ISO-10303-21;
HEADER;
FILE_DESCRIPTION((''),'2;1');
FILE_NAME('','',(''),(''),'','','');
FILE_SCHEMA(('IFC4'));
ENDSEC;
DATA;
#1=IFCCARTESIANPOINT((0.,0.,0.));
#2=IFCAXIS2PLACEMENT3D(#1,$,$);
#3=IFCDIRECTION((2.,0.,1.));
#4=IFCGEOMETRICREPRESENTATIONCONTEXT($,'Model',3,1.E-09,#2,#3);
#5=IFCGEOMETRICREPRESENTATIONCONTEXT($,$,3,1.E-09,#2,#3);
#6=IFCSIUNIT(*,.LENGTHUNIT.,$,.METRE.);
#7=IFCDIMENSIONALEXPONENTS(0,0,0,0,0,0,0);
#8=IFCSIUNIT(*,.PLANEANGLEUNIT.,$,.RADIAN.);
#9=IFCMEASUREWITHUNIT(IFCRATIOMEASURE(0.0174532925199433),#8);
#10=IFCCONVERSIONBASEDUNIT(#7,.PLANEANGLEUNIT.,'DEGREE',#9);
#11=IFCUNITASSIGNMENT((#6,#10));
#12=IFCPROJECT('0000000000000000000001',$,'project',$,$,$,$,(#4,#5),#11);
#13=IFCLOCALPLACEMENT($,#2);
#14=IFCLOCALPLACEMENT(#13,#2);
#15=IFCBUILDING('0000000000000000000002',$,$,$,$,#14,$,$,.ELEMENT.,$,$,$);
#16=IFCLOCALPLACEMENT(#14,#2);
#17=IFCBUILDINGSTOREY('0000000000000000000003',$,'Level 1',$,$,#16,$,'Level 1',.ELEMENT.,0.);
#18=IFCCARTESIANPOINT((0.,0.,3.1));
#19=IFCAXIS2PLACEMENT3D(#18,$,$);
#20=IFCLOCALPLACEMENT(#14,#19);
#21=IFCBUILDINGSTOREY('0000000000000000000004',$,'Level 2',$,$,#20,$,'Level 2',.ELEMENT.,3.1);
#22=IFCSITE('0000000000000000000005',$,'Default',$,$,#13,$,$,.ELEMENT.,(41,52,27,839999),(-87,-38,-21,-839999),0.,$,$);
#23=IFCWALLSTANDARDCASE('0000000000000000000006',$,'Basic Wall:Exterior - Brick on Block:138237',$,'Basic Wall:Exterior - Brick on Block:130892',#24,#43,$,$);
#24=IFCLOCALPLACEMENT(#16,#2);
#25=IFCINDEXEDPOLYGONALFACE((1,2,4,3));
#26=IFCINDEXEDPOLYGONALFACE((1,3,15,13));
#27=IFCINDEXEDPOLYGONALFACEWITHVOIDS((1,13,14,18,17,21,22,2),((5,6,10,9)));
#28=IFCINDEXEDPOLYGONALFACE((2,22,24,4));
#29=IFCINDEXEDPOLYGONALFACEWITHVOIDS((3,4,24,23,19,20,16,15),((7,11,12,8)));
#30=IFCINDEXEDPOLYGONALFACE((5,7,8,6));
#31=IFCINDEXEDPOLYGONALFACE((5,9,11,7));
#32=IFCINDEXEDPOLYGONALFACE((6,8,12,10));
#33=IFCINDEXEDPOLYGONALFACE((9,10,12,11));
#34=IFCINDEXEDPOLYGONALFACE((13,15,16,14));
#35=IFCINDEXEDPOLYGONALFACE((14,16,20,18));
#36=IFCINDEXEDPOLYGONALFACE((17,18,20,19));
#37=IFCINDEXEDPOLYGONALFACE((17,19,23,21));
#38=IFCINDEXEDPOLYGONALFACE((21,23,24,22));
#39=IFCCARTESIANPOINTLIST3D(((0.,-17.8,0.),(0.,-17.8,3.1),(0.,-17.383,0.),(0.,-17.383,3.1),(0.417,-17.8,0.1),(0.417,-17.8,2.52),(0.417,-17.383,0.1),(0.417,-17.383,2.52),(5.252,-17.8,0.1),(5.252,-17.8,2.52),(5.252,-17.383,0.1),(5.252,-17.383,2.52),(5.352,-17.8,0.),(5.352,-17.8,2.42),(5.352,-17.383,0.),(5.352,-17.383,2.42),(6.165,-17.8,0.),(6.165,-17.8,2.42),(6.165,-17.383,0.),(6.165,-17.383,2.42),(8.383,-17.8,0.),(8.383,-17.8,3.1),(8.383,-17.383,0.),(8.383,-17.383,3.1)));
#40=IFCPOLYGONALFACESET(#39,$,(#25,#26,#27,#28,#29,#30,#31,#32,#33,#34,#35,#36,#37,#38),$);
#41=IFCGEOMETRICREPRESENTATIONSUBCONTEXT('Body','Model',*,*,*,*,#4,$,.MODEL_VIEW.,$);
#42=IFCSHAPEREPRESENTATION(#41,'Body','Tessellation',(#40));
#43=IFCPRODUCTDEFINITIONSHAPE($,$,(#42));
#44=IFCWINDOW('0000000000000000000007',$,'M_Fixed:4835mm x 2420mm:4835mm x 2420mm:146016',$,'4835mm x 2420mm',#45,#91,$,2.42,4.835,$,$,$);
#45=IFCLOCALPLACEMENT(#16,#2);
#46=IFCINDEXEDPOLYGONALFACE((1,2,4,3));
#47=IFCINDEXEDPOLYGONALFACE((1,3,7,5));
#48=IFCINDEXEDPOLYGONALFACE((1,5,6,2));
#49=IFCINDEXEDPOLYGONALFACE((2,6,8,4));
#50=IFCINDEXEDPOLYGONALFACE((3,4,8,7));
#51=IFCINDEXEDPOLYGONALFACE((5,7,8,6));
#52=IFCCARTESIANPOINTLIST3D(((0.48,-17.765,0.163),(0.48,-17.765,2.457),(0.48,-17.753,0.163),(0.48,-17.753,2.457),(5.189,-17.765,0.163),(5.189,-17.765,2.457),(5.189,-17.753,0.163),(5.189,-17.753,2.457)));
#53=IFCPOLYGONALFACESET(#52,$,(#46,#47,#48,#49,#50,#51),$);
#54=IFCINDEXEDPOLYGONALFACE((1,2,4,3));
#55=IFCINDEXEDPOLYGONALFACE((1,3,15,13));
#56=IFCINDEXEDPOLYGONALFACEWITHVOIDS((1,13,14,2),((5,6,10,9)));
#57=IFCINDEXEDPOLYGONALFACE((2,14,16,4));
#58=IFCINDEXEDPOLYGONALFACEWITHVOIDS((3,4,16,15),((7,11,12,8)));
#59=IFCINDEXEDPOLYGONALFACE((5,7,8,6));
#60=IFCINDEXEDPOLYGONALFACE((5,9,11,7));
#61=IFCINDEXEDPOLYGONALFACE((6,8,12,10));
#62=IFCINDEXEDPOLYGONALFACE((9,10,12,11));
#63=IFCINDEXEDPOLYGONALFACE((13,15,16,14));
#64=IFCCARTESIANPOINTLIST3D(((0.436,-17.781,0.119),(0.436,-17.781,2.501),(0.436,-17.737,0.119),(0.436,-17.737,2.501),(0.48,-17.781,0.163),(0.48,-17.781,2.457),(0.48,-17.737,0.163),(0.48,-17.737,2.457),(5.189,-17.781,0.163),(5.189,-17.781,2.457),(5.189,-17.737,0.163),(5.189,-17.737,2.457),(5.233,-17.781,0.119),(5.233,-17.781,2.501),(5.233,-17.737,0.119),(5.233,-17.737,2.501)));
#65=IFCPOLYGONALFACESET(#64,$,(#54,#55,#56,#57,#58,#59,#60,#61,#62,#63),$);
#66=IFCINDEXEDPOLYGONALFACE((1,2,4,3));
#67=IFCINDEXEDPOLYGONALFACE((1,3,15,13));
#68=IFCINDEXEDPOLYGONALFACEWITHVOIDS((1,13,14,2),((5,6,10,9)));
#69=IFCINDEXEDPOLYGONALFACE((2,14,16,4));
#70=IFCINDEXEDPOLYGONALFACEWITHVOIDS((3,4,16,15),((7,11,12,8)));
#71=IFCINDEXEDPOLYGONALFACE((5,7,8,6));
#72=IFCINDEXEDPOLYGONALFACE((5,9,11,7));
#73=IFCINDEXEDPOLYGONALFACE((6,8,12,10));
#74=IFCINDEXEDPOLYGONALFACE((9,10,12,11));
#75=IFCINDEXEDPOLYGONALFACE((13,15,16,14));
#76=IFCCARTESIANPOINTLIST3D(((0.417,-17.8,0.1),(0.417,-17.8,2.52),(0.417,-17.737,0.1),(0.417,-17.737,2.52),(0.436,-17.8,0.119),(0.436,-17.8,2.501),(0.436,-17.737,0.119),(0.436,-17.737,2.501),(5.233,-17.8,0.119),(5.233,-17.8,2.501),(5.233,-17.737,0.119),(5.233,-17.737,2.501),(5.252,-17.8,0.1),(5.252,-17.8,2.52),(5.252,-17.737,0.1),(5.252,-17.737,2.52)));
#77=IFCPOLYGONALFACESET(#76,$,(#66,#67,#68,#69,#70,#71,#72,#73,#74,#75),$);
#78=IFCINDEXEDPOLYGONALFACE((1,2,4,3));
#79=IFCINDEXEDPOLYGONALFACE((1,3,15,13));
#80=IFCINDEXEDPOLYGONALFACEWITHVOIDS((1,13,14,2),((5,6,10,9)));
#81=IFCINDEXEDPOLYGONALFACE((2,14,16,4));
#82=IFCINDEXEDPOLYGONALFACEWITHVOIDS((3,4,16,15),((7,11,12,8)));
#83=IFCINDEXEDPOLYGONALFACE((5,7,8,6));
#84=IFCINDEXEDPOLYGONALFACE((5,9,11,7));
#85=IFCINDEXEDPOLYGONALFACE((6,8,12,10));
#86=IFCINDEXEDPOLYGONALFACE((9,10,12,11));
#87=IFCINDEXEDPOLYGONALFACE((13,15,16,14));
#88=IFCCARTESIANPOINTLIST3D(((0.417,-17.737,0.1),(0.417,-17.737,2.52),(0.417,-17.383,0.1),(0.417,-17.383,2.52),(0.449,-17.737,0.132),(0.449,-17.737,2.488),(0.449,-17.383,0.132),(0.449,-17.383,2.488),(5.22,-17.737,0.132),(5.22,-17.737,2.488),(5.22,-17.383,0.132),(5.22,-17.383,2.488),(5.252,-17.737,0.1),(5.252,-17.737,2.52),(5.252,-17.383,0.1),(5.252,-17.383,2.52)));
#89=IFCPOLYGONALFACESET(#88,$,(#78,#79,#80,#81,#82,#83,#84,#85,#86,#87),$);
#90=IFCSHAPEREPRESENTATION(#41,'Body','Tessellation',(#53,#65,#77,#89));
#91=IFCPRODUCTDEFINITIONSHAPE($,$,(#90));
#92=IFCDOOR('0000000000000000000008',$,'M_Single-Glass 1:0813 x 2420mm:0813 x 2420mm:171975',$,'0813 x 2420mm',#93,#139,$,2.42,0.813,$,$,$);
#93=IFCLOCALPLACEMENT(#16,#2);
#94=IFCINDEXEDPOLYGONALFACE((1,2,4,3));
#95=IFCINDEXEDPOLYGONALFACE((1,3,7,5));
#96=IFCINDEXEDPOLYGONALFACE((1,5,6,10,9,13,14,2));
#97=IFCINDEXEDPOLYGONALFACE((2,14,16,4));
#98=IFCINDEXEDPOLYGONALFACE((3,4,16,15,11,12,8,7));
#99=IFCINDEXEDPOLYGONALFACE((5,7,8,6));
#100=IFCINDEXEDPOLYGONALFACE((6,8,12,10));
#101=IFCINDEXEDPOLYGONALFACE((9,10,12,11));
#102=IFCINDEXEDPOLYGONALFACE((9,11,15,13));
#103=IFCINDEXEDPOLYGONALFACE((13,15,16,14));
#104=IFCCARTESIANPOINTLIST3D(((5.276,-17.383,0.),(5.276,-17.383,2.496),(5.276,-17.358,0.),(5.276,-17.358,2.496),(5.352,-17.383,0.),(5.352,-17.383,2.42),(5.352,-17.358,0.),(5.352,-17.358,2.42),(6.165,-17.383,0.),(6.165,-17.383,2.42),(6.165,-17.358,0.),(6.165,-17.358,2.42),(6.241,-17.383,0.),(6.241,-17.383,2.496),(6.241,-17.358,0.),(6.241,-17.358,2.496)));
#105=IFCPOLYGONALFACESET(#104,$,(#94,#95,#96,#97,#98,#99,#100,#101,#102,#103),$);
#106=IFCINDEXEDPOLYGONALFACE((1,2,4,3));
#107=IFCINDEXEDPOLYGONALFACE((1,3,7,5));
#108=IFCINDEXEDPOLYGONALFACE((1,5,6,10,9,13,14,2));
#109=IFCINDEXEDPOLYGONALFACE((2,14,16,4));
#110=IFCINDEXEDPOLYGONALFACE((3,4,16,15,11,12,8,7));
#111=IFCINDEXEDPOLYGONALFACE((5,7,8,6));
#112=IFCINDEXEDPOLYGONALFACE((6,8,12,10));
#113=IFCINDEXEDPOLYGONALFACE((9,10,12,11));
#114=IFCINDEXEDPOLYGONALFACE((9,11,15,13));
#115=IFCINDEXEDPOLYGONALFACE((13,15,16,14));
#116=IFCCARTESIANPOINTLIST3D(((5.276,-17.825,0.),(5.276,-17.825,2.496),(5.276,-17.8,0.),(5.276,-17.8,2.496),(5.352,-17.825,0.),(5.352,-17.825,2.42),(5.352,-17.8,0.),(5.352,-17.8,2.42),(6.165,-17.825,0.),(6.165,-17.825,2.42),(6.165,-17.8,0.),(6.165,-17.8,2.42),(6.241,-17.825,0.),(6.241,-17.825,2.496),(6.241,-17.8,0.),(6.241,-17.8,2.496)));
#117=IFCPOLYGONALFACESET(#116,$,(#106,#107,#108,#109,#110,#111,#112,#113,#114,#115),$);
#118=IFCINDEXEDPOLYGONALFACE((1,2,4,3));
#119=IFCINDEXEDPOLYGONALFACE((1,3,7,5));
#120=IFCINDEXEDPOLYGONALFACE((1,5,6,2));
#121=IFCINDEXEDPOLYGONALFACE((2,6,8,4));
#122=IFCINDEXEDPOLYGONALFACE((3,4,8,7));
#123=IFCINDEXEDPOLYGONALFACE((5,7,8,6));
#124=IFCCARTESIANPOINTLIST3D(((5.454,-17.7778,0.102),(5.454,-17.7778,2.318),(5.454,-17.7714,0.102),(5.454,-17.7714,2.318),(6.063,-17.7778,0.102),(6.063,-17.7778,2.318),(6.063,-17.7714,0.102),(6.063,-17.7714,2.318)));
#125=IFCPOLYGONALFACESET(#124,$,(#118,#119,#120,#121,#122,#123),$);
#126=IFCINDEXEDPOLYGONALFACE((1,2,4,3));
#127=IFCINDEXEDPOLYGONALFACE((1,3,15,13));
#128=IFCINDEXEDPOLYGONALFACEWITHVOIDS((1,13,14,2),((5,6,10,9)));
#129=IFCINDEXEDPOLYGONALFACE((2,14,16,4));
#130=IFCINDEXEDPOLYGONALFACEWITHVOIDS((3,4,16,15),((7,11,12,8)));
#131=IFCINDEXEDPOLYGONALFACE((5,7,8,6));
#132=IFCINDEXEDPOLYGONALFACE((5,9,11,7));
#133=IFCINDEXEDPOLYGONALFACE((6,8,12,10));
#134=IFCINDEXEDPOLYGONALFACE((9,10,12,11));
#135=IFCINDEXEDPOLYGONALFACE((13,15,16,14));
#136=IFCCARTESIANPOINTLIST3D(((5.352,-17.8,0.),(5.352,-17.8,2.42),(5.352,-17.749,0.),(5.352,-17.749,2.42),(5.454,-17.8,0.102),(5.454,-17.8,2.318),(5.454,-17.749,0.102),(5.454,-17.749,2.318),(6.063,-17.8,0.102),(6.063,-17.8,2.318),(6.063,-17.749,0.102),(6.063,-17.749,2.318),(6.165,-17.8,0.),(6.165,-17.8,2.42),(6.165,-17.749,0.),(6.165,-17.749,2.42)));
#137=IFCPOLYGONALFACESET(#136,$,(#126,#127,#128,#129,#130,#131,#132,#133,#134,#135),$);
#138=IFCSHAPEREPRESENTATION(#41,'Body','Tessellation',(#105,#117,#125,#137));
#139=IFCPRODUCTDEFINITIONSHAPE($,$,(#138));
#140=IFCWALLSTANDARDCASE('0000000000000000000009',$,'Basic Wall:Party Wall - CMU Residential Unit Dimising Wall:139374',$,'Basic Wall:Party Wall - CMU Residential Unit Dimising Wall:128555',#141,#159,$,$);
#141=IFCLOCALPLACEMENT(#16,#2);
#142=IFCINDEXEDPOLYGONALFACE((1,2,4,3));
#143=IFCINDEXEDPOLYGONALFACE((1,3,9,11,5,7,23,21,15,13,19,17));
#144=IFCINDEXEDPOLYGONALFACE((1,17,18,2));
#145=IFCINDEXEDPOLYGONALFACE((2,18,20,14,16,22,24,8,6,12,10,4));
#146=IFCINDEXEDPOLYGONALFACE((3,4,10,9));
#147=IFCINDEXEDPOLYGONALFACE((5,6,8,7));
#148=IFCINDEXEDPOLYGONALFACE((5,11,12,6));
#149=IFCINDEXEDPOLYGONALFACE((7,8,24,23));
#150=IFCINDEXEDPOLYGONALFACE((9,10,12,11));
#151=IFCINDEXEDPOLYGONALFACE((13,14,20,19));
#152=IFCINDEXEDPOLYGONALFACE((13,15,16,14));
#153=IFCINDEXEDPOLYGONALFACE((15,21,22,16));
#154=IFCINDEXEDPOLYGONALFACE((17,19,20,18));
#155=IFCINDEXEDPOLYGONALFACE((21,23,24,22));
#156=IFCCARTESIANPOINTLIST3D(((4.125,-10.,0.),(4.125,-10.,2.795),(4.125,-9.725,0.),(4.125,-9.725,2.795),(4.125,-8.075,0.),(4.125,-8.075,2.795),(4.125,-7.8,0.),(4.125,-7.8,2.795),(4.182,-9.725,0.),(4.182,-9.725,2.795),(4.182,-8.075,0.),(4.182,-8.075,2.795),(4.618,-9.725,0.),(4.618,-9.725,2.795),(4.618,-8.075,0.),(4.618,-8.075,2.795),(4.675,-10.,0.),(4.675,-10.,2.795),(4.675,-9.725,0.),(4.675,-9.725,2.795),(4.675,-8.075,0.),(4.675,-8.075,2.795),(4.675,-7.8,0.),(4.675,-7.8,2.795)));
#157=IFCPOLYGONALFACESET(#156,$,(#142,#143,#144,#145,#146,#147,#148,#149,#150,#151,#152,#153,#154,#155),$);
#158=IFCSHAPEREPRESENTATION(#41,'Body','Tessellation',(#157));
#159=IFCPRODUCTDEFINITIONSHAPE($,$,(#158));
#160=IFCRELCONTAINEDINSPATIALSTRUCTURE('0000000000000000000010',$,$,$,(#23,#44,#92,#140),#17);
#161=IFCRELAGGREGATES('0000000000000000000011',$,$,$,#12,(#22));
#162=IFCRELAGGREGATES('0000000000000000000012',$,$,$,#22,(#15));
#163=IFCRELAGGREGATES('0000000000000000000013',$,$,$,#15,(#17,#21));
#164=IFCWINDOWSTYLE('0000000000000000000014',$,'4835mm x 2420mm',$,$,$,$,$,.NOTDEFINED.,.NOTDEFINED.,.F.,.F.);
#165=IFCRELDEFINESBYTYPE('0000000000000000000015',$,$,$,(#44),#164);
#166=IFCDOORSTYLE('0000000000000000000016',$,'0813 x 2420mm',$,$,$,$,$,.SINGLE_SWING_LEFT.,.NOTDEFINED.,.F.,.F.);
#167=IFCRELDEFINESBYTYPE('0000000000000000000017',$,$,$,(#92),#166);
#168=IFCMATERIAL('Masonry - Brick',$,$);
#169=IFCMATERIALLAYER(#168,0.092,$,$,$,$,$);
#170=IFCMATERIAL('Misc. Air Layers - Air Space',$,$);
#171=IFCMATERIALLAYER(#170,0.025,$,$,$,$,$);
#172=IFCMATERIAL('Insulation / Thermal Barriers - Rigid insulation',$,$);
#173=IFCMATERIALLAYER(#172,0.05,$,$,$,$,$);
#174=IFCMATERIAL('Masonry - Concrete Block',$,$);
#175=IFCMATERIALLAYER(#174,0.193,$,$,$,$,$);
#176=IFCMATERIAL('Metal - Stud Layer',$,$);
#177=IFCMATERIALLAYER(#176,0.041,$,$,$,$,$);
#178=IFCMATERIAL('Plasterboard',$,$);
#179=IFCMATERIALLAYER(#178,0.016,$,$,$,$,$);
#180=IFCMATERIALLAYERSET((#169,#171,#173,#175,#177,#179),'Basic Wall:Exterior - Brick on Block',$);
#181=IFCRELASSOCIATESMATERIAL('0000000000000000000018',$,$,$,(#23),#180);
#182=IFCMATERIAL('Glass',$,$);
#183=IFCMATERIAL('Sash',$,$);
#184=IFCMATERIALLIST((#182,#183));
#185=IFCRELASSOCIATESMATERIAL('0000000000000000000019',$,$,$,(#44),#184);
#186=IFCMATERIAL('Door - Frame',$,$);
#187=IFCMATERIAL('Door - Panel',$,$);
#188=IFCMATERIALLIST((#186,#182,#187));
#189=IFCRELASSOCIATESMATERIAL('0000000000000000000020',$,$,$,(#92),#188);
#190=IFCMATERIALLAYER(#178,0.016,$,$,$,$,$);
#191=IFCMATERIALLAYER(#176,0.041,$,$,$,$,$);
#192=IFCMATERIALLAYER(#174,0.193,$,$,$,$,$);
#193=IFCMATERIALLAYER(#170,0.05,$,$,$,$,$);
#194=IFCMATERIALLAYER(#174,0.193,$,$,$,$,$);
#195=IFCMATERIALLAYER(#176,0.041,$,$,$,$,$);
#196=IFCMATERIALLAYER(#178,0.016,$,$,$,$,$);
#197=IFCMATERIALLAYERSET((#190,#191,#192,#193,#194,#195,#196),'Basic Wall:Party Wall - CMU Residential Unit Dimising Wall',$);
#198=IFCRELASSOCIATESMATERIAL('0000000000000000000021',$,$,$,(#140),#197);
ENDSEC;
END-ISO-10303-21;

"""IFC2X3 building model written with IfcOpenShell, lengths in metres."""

from ifc_helpers import new_model, entity, si_unit, converted_unit, direction, frame, frame_2d, origin, origin_2d_with_axis, place, context, subcontext, project, spatial, polyline, rectangle, outline, extrude, clip, bounded_halfspace, source, transform, mapped, material, material_list, layer, layer_set, layer_usage, type_object, type_shapes, element, fill, save


model = new_model("IFC2X3")

# Units and contexts
model_context = context("Model", 3, precision=1e-09, world=origin(), true_north=direction((2.0, 0.0, 1.0)))
context_of_model = context(None, 3, precision=1e-09, world=origin(), true_north=direction((2.0, 0.0, 1.0)))
body_context = subcontext(model_context, "Body", "Model", "MODEL_VIEW")
ifc_project = project(units=[si_unit("LENGTHUNIT", "METRE"), converted_unit("PLANEANGLEUNIT", "DEGREE", entity("IfcRatioMeasure", 0.0174532925199433), si_unit("PLANEANGLEUNIT", "RADIAN"), dimensions=[0, 0, 0, 0, 0, 0, 0])], contexts=[model_context, context_of_model])

# Site, building, storey
site_placement = place(None, origin())
site = spatial("IfcSite", under=ifc_project, at=site_placement, Name="Default", CompositionType="ELEMENT", RefLatitude=(41, 52, 27, 839999), RefLongitude=(-87, -38, -21, -839999), RefElevation=0.0)
building_placement = place(site_placement, origin())
building = spatial("IfcBuilding", under=site, at=building_placement, CompositionType="ELEMENT")
storey_1_placement = place(building_placement, origin())
storey_1 = spatial("IfcBuildingStorey", under=building, at=storey_1_placement, Name="Level 1", LongName="Level 1", CompositionType="ELEMENT", Elevation=0.0)

# Wall, openings, window, door
ifc_material_1 = material(Name="Masonry - Brick")
ifc_layer_1 = layer(ifc_material_1, 0.092)
ifc_material_2 = material(Name="Misc. Air Layers - Air Space")
ifc_layer_2 = layer(ifc_material_2, 0.025)
ifc_material_3 = material(Name="Insulation / Thermal Barriers - Rigid insulation")
ifc_layer_3 = layer(ifc_material_3, 0.05)
ifc_material_4 = material(Name="Masonry - Concrete Block")
ifc_layer_4 = layer(ifc_material_4, 0.193)
ifc_material_5 = material(Name="Metal - Stud Layer")
ifc_layer_5 = layer(ifc_material_5, 0.041)
ifc_material_6 = material(Name="Plasterboard")
ifc_layer_6 = layer(ifc_material_6, 0.016)
ifc_layer_set_1 = layer_set([ifc_layer_1, ifc_layer_2, ifc_layer_3, ifc_layer_4, ifc_layer_5, ifc_layer_6], Name="Basic Wall:Exterior - Brick on Block")
ifc_layer_usage_1 = layer_usage(ifc_layer_set_1, "AXIS2", "NEGATIVE", 0.2085)
wall_1_placement = place(storey_1_placement, frame((8.383, -17.5915, 0.0), z_axis=(0.0, 0.0, 1.0), x_axis=(-1.0, 0.0, 0.0)))
wall_1 = element("IfcWallStandardCase", 1, at=wall_1_placement, inside=storey_1, material=ifc_layer_usage_1, Name="Basic Wall:Exterior - Brick on Block:138237", ObjectType="Basic Wall:Exterior - Brick on Block:130892", context=body_context, shape_type="SweptSolid", body=[
    extrude(rectangle(XDim=8.383, YDim=0.417, at=frame_2d((4.1915, 0.0), x_axis=(-1.0, 0.0))), origin(), (0.0, 0.0, 1.0), 3.1),
])
opening_1_placement = place(wall_1_placement, frame((3.131, -0.2085, 0.1)))
opening_1 = element("IfcOpeningElement", 2, at=opening_1_placement, cuts=wall_1, ObjectType="Opening", context=body_context, shape_type="SweptSolid", body=[
    extrude(rectangle(XDim=2.42, YDim=4.835, at=frame_2d((1.21, 2.4175), x_axis=(1.0, 0.0))), frame((0.0, 0.0, 0.0), z_axis=(0.0, 1.0, 0.0), x_axis=(0.0, 0.0, 1.0)), (0.0, 0.0, 1.0), 0.417),
])
opening_2_placement = place(wall_1_placement, frame((2.218, -0.2085, 0.0)))
opening_2 = element("IfcOpeningElement", 3, at=opening_2_placement, cuts=wall_1, ObjectType="Opening", context=body_context, shape_type="SweptSolid", body=[
    extrude(rectangle(XDim=0.813, YDim=2.42, at=frame_2d((1.21, 0.4065), x_axis=(0.0, -1.0))), frame((0.0, 0.0, 0.0), z_axis=(0.0, 1.0, 0.0), x_axis=(0.0, 0.0, 1.0)), (0.0, 0.0, 1.0), 0.417),
])
ifc_material_7 = material(Name="Glass")
ifc_material_8 = material(Name="Sash")
ifc_material_list_1 = material_list([ifc_material_7, ifc_material_8])
window_style = type_object("IfcWindowStyle", Name="4835mm x 2420mm", ConstructionType="NOTDEFINED", OperationType="NOTDEFINED", ParameterTakesPrecedence=False, Sizeable=False)
shared_shape_1 = source(origin(), body_context, "Body", "SweptSolid", [
    extrude(rectangle(XDim=0.012, YDim=4.709, at=origin_2d_with_axis()), frame((2.4175, 0.376, 0.063), z_axis=(0.0, 0.0, 1.0), x_axis=(0.0, -1.0, 0.0)), (0.0, 0.0, 1.0), 2.294),
    extrude(outline(polyline([(-2.3985, -1.191), (2.3985, -1.191), (2.3985, 1.191), (-2.3985, 1.191), (-2.3985, -1.191)]), holes=[polyline([(-2.3545, -1.147), (-2.3545, 1.147), (2.3545, 1.147), (2.3545, -1.147), (-2.3545, -1.147)])]), frame((2.4175, 0.354, 1.21), z_axis=(0.0, 1.0, 0.0), x_axis=(1.0, 0.0, 0.0)), (0.0, 0.0, 1.0), 0.044),
    extrude(outline(polyline([(-2.4175, -1.21), (2.4175, -1.21), (2.4175, 1.21), (-2.4175, 1.21), (-2.4175, -1.21)]), holes=[polyline([(-2.3985, -1.191), (-2.3985, 1.191), (2.3985, 1.191), (2.3985, -1.191), (-2.3985, -1.191)])]), frame((2.4175, 0.354, 1.21), z_axis=(0.0, 1.0, 0.0), x_axis=(1.0, 0.0, 0.0)), (0.0, 0.0, 1.0), 0.063),
    extrude(outline(polyline([(-2.4175, -1.21), (2.4175, -1.21), (2.4175, 1.21), (-2.4175, 1.21), (-2.4175, -1.21)]), holes=[polyline([(-2.3855, -1.178), (-2.3855, 1.178), (2.3855, 1.178), (2.3855, -1.178), (-2.3855, -1.178)])]), frame((2.4175, 0.0, 1.21), z_axis=(0.0, 1.0, 0.0), x_axis=(1.0, 0.0, 0.0)), (0.0, 0.0, 1.0), 0.354),
])
type_shapes(window_style, [shared_shape_1])
window_placement = place(opening_1_placement, origin())
window = element("IfcWindow", 4, at=window_placement, inside=storey_1, type_object=window_style, material=ifc_material_list_1, Name="M_Fixed:4835mm x 2420mm:4835mm x 2420mm:146016", ObjectType="4835mm x 2420mm", OverallHeight=2.42, OverallWidth=4.835, context=body_context, shape_type="MappedRepresentation", body=[
    mapped(shared_shape_1, transform((0.0, 0.0, 0.0), scale=1.0)),
])
fill(opening_1, window)
ifc_material_9 = material(Name="Door - Frame")
ifc_material_10 = material(Name="Door - Panel")
ifc_material_list_2 = material_list([ifc_material_9, ifc_material_7, ifc_material_10])
door_style_1 = type_object("IfcDoorStyle", Name="0813 x 2420mm", ConstructionType="NOTDEFINED", OperationType="SINGLE_SWING_LEFT", ParameterTakesPrecedence=False, Sizeable=False)
shared_shape_2 = source(origin(), body_context, "Body", "SweptSolid", [
    extrude(outline(polyline([(-0.4065, -1.191), (-0.4065, 1.229), (-0.4825, 1.229), (-0.4825, -1.267), (0.4825, -1.267), (0.4825, 1.229), (0.4065, 1.229), (0.4065, -1.191), (-0.4065, -1.191)])), frame((0.4065, 0.0, 1.229), z_axis=(0.0, 1.0, 0.0), x_axis=(1.0, 0.0, 0.0)), (0.0, 0.0, -1.0), 0.025),
    extrude(outline(polyline([(-0.4065, -1.191), (-0.4065, 1.229), (-0.4825, 1.229), (-0.4825, -1.267), (0.4825, -1.267), (0.4825, 1.229), (0.4065, 1.229), (0.4065, -1.191), (-0.4065, -1.191)])), frame((0.4065, 0.442, 1.229), z_axis=(0.0, 1.0, 0.0), x_axis=(1.0, 0.0, 0.0)), (0.0, 0.0, -1.0), 0.025),
    extrude(rectangle(XDim=0.609, YDim=0.0064, at=frame_2d((0.0, 0.0), x_axis=(1.0, 0.0))), frame((0.4065, 0.3916, 0.102)), (0.0, 0.0, 1.0), 2.216),
    extrude(outline(polyline([(-1.21, -0.4065), (1.21, -0.4065), (1.21, 0.4065), (-1.21, 0.4065), (-1.21, -0.4065)]), holes=[polyline([(-1.108, 0.3045), (1.108, 0.3045), (1.108, -0.3045), (-1.108, -0.3045), (-1.108, 0.3045)])]), frame((0.4065, 0.417, 1.21), z_axis=(0.0, -1.0, 0.0), x_axis=(0.0, 0.0, -1.0)), (0.0, 0.0, 1.0), 0.051),
])
type_shapes(door_style_1, [shared_shape_2])
door_1_placement = place(opening_2_placement, origin())
door_1 = element("IfcDoor", 5, at=door_1_placement, inside=storey_1, type_object=door_style_1, material=ifc_material_list_2, Name="M_Single-Glass 1:0813 x 2420mm:0813 x 2420mm:171975", ObjectType="0813 x 2420mm", OverallHeight=2.42, OverallWidth=0.813, context=body_context, shape_type="MappedRepresentation", body=[
    mapped(shared_shape_2, transform((0.0, 0.0, 0.0), scale=1.0)),
])
fill(opening_2, door_1)

# Wall
ifc_layer_7 = layer(ifc_material_6, 0.016)
ifc_layer_8 = layer(ifc_material_5, 0.041)
ifc_layer_9 = layer(ifc_material_4, 0.193)
ifc_layer_10 = layer(ifc_material_2, 0.05)
ifc_layer_11 = layer(ifc_material_4, 0.193)
ifc_layer_12 = layer(ifc_material_5, 0.041)
ifc_layer_13 = layer(ifc_material_6, 0.016)
ifc_layer_set_2 = layer_set([ifc_layer_7, ifc_layer_8, ifc_layer_9, ifc_layer_10, ifc_layer_11, ifc_layer_12, ifc_layer_13], Name="Basic Wall:Party Wall - CMU Residential Unit Dimising Wall")
ifc_layer_usage_2 = layer_usage(ifc_layer_set_2, "AXIS2", "NEGATIVE", 0.275)
wall_2_placement = place(storey_1_placement, frame((4.4, -10.0, 0.0), z_axis=(0.0, 0.0, 1.0), x_axis=(0.0, 1.0, 0.0)))
element("IfcWallStandardCase", 6, at=wall_2_placement, inside=storey_1, material=ifc_layer_usage_2, Name="Basic Wall:Party Wall - CMU Residential Unit Dimising Wall:139374", ObjectType="Basic Wall:Party Wall - CMU Residential Unit Dimising Wall:128555", context=body_context, shape_type="Clipping", body=[
    clip(clip(extrude(rectangle(XDim=2.2, YDim=0.55, at=frame_2d((1.1, 0.0), x_axis=(-1.0, 0.0))), origin(), (0.0, 0.0, 1.0), 2.795), bounded_halfspace(frame((1.925, 0.218, 0.0), z_axis=(0.0, -1.0, 0.0), x_axis=(1.0, 0.0, 0.0)), True, frame((1.925, 0.218, 0.0), z_axis=(0.0, -1.0, 0.0), x_axis=(1.0, 0.0, 0.0)), polyline([(0.0, 0.0), (0.0, 2.795), (-1.65, 2.795), (-1.65, 0.0), (0.0, 0.0)]))), bounded_halfspace(frame((0.275, -0.218, 0.0), z_axis=(0.0, 1.0, 0.0), x_axis=(-1.0, 0.0, 0.0)), True, frame((0.275, -0.218, 0.0), z_axis=(0.0, 1.0, 0.0), x_axis=(-1.0, 0.0, 0.0)), polyline([(0.0, 0.0), (0.0, 2.795), (-1.65, 2.795), (-1.65, 0.0), (0.0, 0.0)]))),
])

# Shared definitions
storey_2_placement = place(building_placement, frame((0.0, 0.0, 3.1)))
storey_2 = spatial("IfcBuildingStorey", under=building, at=storey_2_placement, Name="Level 2", LongName="Level 2", CompositionType="ELEMENT", Elevation=3.1)

save(model, "model.ifc")
